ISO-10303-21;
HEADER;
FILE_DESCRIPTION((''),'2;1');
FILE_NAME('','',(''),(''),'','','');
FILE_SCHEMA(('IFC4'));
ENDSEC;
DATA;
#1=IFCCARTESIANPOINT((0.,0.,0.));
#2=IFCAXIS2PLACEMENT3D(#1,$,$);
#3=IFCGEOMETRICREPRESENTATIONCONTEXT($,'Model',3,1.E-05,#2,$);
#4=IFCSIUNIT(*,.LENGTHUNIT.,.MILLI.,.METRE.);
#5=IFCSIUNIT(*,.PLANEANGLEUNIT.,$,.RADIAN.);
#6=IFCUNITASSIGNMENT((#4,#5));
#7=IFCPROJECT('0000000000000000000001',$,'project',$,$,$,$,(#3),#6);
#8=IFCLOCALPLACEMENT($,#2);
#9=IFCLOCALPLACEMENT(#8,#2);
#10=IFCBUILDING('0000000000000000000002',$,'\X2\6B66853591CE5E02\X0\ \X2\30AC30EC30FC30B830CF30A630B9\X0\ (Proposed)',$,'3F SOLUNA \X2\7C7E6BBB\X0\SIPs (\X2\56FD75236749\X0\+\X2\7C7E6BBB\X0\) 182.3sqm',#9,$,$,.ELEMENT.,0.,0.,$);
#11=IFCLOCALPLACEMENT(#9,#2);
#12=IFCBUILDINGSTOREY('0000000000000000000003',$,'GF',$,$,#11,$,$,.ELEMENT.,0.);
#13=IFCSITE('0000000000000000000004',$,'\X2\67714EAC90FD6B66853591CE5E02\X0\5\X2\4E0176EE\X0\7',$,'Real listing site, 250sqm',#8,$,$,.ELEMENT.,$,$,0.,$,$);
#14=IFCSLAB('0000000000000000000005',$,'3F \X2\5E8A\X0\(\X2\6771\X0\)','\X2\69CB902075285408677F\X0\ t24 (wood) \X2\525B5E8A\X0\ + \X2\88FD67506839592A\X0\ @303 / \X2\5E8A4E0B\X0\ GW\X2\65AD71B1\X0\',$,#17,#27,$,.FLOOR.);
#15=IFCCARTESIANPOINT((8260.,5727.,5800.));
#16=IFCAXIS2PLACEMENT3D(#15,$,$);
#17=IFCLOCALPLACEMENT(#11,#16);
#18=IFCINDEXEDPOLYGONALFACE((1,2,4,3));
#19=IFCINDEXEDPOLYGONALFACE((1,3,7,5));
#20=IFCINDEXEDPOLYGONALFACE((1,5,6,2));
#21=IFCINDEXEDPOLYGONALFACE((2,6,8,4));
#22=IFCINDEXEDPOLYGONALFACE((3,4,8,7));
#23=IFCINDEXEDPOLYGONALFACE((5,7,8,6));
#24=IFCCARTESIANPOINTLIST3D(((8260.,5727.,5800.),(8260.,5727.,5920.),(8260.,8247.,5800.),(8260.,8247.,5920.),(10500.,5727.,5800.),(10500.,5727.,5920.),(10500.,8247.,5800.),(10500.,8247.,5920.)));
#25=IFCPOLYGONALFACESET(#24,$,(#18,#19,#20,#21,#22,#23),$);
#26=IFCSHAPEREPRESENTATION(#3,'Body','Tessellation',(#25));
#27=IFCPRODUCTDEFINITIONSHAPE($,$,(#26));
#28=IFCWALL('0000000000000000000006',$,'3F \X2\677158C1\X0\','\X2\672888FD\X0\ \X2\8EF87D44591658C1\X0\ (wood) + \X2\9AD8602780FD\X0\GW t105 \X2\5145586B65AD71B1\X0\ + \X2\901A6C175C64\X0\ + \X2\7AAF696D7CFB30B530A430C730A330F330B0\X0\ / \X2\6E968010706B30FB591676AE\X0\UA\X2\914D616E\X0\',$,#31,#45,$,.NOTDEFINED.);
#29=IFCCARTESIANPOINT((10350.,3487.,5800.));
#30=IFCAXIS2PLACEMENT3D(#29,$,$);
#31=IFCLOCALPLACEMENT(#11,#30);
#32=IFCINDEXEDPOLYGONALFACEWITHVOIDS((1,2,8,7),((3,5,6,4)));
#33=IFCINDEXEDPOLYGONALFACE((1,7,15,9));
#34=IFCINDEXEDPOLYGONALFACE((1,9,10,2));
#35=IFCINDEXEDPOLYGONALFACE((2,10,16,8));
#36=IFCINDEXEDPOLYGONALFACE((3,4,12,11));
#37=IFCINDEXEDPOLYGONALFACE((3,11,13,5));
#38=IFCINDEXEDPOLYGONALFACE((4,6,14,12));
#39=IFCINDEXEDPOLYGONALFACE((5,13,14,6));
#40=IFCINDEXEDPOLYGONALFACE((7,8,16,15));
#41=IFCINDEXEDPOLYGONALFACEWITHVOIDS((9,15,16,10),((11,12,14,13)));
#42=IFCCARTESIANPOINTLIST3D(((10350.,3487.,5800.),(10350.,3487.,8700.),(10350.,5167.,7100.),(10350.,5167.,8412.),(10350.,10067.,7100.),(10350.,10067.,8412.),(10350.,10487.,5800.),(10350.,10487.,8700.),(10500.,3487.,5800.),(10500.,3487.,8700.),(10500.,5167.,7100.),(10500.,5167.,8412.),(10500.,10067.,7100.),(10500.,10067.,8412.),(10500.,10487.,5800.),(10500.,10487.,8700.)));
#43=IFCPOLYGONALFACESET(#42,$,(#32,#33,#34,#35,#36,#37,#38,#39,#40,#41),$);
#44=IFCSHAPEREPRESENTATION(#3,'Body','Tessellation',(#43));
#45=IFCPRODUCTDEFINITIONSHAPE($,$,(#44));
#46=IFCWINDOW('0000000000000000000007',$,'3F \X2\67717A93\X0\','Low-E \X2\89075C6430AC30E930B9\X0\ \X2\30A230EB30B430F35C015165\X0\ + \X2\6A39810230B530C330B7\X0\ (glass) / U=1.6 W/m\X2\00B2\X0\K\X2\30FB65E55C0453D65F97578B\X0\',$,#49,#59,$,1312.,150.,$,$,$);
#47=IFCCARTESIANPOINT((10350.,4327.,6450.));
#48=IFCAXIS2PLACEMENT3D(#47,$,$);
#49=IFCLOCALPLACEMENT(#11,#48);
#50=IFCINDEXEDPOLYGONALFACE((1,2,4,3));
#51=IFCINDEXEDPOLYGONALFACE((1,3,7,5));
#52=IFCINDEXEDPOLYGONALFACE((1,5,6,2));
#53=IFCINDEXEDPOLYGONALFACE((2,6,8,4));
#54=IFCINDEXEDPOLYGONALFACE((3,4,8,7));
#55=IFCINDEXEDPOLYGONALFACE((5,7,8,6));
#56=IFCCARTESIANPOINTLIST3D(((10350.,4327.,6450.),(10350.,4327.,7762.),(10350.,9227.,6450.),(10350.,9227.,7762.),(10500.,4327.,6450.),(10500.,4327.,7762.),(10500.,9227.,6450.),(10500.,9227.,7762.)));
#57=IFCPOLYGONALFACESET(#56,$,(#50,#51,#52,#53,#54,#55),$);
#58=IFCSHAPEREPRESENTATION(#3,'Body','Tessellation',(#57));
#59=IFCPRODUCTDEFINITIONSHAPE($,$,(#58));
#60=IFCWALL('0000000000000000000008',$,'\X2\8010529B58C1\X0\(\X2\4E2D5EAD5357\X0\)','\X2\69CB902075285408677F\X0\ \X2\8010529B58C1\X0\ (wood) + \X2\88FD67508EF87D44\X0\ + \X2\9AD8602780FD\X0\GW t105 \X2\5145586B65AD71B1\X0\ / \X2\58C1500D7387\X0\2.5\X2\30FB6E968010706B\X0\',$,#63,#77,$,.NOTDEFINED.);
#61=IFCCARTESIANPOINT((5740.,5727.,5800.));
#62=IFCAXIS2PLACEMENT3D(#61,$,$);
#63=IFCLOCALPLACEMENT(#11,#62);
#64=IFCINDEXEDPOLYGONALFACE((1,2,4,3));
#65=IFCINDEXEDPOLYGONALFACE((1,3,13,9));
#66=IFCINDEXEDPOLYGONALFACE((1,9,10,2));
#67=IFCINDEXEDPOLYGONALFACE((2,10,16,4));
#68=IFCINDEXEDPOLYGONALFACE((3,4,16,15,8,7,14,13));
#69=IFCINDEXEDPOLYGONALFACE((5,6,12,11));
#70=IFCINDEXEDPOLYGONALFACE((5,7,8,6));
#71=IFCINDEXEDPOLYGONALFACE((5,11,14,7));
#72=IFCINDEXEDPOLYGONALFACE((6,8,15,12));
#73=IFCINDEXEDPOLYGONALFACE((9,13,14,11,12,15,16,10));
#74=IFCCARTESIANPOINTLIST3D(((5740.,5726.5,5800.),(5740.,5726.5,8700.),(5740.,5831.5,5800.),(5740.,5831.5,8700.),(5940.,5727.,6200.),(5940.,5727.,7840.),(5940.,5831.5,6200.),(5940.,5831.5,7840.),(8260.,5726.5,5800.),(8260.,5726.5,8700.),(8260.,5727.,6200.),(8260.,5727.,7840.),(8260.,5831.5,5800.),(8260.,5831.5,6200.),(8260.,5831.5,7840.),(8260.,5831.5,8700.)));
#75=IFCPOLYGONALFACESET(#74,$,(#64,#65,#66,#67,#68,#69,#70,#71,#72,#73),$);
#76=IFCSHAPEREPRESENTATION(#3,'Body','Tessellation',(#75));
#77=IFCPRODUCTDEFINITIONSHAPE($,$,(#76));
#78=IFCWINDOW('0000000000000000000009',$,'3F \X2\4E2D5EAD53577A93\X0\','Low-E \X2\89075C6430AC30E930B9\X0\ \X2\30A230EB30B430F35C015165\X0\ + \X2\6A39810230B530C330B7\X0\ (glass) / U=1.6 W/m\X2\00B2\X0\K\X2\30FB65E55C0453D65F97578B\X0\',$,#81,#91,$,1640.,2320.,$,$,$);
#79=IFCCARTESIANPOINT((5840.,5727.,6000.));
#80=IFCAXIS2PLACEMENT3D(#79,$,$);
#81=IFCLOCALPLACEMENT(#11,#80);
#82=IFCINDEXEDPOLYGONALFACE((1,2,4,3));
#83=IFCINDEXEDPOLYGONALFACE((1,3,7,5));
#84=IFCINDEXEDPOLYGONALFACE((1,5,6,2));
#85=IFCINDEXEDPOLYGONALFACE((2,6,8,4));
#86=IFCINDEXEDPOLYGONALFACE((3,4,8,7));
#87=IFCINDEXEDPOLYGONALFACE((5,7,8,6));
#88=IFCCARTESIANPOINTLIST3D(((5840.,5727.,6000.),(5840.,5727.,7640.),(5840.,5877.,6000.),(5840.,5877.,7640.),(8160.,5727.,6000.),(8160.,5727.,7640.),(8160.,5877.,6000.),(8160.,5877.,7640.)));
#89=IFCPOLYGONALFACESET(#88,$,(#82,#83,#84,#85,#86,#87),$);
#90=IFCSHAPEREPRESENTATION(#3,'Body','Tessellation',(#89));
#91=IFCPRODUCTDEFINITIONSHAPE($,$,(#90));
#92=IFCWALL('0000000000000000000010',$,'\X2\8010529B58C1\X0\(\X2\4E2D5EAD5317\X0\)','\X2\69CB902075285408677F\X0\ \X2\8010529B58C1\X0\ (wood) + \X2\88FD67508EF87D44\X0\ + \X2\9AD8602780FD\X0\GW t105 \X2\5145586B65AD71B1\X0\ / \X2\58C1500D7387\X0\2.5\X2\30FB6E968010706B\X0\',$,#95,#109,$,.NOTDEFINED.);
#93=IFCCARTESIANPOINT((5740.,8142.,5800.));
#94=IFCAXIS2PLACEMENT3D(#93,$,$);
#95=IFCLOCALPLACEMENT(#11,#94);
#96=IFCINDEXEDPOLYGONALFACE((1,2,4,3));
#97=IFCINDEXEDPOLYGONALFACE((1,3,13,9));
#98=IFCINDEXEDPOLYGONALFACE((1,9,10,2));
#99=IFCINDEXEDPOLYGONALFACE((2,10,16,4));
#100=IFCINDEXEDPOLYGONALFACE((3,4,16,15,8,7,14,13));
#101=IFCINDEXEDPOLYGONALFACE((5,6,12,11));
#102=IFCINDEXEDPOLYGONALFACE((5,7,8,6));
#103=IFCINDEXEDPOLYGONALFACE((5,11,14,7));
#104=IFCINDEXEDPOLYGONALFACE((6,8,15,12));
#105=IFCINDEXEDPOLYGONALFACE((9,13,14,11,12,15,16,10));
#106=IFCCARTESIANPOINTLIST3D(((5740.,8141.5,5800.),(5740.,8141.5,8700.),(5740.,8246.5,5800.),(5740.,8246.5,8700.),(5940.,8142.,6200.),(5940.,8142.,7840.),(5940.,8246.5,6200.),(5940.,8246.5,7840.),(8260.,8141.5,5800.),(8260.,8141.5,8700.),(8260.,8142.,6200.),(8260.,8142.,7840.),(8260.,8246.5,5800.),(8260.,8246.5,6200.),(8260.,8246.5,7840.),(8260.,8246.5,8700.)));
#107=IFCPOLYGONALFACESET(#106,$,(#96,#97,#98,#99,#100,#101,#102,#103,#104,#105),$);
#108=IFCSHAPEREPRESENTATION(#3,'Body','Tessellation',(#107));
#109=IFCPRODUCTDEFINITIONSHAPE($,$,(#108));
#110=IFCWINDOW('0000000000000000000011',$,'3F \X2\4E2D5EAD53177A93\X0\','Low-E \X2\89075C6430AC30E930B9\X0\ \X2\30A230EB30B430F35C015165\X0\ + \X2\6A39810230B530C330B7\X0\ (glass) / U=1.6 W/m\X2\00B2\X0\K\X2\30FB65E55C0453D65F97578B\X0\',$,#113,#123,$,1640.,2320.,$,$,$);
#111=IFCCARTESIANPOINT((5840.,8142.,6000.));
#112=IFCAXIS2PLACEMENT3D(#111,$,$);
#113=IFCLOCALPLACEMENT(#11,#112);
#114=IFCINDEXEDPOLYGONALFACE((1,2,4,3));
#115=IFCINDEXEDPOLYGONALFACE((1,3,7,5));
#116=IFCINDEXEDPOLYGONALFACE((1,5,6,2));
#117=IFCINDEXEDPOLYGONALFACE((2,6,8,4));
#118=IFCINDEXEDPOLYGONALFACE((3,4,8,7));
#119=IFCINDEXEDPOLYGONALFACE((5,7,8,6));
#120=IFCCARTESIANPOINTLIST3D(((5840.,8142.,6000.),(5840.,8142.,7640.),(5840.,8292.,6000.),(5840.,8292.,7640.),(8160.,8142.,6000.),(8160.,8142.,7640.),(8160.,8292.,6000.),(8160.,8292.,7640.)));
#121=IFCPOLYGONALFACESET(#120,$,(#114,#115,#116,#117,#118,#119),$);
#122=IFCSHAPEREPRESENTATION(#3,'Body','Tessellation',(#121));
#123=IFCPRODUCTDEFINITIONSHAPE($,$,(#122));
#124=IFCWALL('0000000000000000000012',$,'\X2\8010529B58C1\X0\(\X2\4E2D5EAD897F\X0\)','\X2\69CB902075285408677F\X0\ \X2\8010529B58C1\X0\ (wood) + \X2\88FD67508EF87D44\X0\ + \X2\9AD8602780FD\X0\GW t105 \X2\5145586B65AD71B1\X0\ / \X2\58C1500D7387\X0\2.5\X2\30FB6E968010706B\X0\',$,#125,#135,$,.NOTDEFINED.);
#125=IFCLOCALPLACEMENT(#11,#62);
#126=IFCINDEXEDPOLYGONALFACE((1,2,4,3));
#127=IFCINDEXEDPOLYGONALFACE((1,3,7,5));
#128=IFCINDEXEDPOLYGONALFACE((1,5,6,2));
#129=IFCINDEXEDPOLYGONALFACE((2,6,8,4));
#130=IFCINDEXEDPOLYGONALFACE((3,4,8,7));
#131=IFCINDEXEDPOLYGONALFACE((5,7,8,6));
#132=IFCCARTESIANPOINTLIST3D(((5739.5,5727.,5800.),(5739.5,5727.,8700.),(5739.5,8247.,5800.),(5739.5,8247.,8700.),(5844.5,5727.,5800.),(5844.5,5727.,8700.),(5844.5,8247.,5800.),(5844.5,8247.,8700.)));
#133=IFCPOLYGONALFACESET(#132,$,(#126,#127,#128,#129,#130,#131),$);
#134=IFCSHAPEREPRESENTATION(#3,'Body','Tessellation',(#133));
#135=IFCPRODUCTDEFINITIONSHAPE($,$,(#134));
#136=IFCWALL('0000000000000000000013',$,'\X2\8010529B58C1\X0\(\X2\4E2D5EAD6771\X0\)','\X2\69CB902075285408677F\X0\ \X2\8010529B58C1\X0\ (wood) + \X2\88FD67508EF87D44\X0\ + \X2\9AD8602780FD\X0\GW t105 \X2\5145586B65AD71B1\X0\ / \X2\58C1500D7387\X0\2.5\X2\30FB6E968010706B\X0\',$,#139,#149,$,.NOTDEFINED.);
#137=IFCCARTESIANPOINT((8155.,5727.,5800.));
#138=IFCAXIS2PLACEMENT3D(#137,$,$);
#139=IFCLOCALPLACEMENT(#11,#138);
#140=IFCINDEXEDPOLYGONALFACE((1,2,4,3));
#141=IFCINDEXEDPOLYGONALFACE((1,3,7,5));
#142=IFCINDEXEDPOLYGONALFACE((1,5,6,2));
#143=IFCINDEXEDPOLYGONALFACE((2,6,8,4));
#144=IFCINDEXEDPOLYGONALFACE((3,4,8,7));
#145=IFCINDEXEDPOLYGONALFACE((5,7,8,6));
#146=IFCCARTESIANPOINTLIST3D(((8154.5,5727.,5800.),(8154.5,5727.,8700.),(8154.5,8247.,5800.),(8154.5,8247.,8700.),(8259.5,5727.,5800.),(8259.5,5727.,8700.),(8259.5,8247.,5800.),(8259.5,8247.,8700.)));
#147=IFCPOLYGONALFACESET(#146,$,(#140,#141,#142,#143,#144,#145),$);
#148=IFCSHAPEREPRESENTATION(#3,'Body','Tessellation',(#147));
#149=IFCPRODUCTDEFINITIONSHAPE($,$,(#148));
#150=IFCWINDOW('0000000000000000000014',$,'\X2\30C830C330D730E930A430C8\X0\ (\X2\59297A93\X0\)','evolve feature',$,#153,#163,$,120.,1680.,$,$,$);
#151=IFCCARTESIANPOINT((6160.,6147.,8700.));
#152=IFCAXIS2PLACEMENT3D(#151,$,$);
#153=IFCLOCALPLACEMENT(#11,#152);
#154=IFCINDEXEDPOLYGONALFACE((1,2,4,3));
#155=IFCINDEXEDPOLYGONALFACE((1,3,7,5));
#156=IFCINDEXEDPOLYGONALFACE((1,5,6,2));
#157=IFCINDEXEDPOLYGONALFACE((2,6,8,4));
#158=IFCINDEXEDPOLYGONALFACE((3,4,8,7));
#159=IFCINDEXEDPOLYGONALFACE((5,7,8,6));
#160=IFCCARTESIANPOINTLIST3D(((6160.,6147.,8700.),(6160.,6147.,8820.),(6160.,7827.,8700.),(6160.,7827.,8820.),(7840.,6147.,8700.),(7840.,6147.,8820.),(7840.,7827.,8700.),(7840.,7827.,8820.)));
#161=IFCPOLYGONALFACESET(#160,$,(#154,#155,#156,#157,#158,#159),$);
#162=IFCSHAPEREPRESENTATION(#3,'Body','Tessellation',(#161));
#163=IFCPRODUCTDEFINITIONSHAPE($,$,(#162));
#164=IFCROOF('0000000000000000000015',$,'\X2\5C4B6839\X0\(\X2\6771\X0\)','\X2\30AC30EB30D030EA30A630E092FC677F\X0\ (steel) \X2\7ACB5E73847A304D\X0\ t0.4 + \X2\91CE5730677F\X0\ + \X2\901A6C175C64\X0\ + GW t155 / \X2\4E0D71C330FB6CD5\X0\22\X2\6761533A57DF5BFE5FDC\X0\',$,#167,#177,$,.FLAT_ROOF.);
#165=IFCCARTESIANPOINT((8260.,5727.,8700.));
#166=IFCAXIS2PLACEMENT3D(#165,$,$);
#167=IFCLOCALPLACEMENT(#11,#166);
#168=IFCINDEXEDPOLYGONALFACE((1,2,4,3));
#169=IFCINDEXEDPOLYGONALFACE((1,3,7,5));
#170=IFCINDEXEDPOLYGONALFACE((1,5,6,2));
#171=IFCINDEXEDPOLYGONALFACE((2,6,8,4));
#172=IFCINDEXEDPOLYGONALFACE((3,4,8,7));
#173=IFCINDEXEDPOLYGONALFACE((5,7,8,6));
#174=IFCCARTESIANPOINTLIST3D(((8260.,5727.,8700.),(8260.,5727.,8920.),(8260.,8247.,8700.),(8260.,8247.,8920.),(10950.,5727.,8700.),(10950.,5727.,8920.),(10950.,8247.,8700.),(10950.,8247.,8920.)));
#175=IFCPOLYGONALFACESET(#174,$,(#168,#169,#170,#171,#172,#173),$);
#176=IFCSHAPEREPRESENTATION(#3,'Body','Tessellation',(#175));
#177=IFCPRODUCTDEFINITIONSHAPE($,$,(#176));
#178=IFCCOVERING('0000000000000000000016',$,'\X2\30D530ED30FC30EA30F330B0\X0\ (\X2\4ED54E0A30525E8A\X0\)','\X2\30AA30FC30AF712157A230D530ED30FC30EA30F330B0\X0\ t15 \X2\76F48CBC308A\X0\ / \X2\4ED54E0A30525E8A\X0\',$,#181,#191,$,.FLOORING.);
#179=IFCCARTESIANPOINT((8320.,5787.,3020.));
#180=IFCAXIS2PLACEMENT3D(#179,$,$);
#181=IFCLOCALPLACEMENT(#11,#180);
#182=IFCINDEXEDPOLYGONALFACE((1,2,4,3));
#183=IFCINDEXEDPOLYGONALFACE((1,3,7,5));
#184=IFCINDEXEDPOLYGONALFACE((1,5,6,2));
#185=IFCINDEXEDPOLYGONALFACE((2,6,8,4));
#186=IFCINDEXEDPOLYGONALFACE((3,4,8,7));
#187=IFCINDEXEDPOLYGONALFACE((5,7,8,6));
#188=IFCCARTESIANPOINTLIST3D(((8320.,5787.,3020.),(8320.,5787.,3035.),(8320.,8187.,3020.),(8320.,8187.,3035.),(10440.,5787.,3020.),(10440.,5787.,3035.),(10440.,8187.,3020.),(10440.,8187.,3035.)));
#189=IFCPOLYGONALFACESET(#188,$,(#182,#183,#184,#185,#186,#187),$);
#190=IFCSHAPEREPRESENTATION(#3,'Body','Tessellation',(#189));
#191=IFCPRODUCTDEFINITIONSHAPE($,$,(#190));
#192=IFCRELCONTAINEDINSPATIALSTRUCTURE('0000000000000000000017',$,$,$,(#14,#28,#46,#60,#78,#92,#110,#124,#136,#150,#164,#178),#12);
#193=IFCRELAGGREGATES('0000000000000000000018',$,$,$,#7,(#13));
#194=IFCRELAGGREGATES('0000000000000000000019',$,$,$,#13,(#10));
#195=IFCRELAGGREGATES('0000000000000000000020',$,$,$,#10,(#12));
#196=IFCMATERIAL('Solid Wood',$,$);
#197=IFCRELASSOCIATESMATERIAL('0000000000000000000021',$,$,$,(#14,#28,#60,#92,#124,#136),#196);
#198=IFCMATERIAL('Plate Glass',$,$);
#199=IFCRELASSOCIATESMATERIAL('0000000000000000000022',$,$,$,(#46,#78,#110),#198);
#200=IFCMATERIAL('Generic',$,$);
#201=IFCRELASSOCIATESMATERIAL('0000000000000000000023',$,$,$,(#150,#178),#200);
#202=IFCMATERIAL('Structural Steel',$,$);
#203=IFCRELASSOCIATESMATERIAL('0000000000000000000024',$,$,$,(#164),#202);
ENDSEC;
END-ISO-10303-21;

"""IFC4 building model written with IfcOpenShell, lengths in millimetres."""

from ifc_helpers import new_model, si_unit, frame, frame_2d, origin, place, context, project, spatial, rectangle, extrude, material, element, fill, save


model = new_model("IFC4")

# Units and contexts
model_context = context("Model", 3, precision=1e-05, world=origin())
ifc_project = project(units=[si_unit("LENGTHUNIT", "METRE", prefix="MILLI"), si_unit("PLANEANGLEUNIT", "RADIAN")], contexts=[model_context])

# Site, building, storey
site_placement = place(None, origin())
site = spatial("IfcSite", under=ifc_project, at=site_placement, Name="東京都武蔵野市5丁目7", ObjectType="Real listing site, 250sqm", CompositionType="ELEMENT", RefElevation=0.0)
building_placement = place(site_placement, origin())
building = spatial("IfcBuilding", under=site, at=building_placement, Name="武蔵野市 ガレージハウス (Proposed)", ObjectType="3F SOLUNA 籾殻SIPs (国産杉+籾殻) 182.3sqm", CompositionType="ELEMENT", ElevationOfRefHeight=0.0, ElevationOfTerrain=0.0)
storey_placement = place(building_placement, origin())
storey = spatial("IfcBuildingStorey", under=building, at=storey_placement, Name="GF", CompositionType="ELEMENT", Elevation=0.0)

# Slab
ifc_material_1 = material(Name="Solid Wood")
slab_placement = place(storey_placement, frame((8260.0, 5727.0, 5800.0)))
element("IfcSlab", 1, at=slab_placement, inside=storey, material=ifc_material_1, Name="3F 床(東)", Description="構造用合板 t24 (wood) 剛床 + 製材根太 @303 / 床下 GW断熱", PredefinedType="FLOOR", context=model_context, shape_type="SweptSolid", body=[
    extrude(rectangle(XDim=2240.0, YDim=2520.0, at=frame_2d((1120.0, 1260.0))), frame((8260.0, 5727.0, 5800.0)), (0.0, 0.0, 1.0), 120.0),
])

# Walls, openings, windows
wall_1_placement = place(storey_placement, frame((10350.0, 3487.0, 5800.0)))
wall_1 = element("IfcWall", 2, at=wall_1_placement, inside=storey, material=ifc_material_1, Name="3F 東壁", Description="木製 軸組外壁 (wood) + 高性能GW t105 充填断熱 + 通気層 + 窯業系サイディング / 準耐火・外皮UA配慮", PredefinedType="NOTDEFINED", context=model_context, shape_type="SweptSolid", body=[
    extrude(rectangle(XDim=150.0, YDim=7000.0, at=frame_2d((75.0, 3500.0))), frame((10350.0, 3487.0, 5800.0)), (0.0, 0.0, 1.0), 2900.0),
])
opening_1_placement = place(storey_placement, frame((10350.0, 4327.0, 6450.0)))
opening_1 = element("IfcOpeningElement", 3, at=opening_1_placement, cuts=wall_1, PredefinedType="NOTDEFINED", context=model_context, shape_type="SweptSolid", body=[
    extrude(rectangle(XDim=150.0, YDim=4900.0, at=frame_2d((75.0, 2450.0))), frame((10350.0, 4327.0, 6450.0)), (0.0, 0.0, 1.0), 1312.0),
])
ifc_material_2 = material(Name="Plate Glass")
window_1_placement = place(storey_placement, frame((10350.0, 4327.0, 6450.0)))
window_1 = element("IfcWindow", 4, at=window_1_placement, inside=storey, material=ifc_material_2, Name="3F 東窓", Description="Low-E 複層ガラス アルゴン封入 + 樹脂サッシ (glass) / U=1.6 W/m²K・日射取得型", OverallHeight=1312.0, OverallWidth=150.0, context=model_context, shape_type="SweptSolid", body=[
    extrude(rectangle(XDim=150.0, YDim=4900.0, at=frame_2d((75.0, 2450.0))), frame((10350.0, 4327.0, 6450.0)), (0.0, 0.0, 1.0), 1312.0),
])
fill(opening_1, window_1)
wall_2_placement = place(storey_placement, frame((5740.0, 5727.0, 5800.0)))
wall_2 = element("IfcWall", 5, at=wall_2_placement, inside=storey, material=ifc_material_1, Name="耐力壁(中庭南)", Description="構造用合板 耐力壁 (wood) + 製材軸組 + 高性能GW t105 充填断熱 / 壁倍率2.5・準耐火", PredefinedType="NOTDEFINED", context=model_context, shape_type="SweptSolid", body=[
    extrude(rectangle(XDim=2520.0, YDim=105.0, at=frame_2d((1260.0, 52.0))), frame((5740.0, 5727.0, 5800.0)), (0.0, 0.0, 1.0), 2900.0),
])
opening_2_placement = place(storey_placement, frame((5840.0, 5727.0, 6000.0)))
opening_2 = element("IfcOpeningElement", 6, at=opening_2_placement, cuts=wall_2, PredefinedType="NOTDEFINED", context=model_context, shape_type="SweptSolid", body=[
    extrude(rectangle(XDim=2320.0, YDim=150.0, at=frame_2d((1160.0, 75.0))), frame((5840.0, 5727.0, 6000.0)), (0.0, 0.0, 1.0), 1640.0),
])
window_2_placement = place(storey_placement, frame((5840.0, 5727.0, 6000.0)))
window_2 = element("IfcWindow", 7, at=window_2_placement, inside=storey, material=ifc_material_2, Name="3F 中庭南窓", Description="Low-E 複層ガラス アルゴン封入 + 樹脂サッシ (glass) / U=1.6 W/m²K・日射取得型", OverallHeight=1640.0, OverallWidth=2320.0, context=model_context, shape_type="SweptSolid", body=[
    extrude(rectangle(XDim=2320.0, YDim=150.0, at=frame_2d((1160.0, 75.0))), frame((5840.0, 5727.0, 6000.0)), (0.0, 0.0, 1.0), 1640.0),
])
fill(opening_2, window_2)
wall_3_placement = place(storey_placement, frame((5740.0, 8142.0, 5800.0)))
wall_3 = element("IfcWall", 8, at=wall_3_placement, inside=storey, material=ifc_material_1, Name="耐力壁(中庭北)", Description="構造用合板 耐力壁 (wood) + 製材軸組 + 高性能GW t105 充填断熱 / 壁倍率2.5・準耐火", PredefinedType="NOTDEFINED", context=model_context, shape_type="SweptSolid", body=[
    extrude(rectangle(XDim=2520.0, YDim=105.0, at=frame_2d((1260.0, 52.0))), frame((5740.0, 8142.0, 5800.0)), (0.0, 0.0, 1.0), 2900.0),
])
opening_3_placement = place(storey_placement, frame((5840.0, 8142.0, 6000.0)))
opening_3 = element("IfcOpeningElement", 9, at=opening_3_placement, cuts=wall_3, PredefinedType="NOTDEFINED", context=model_context, shape_type="SweptSolid", body=[
    extrude(rectangle(XDim=2320.0, YDim=150.0, at=frame_2d((1160.0, 75.0))), frame((5840.0, 8142.0, 6000.0)), (0.0, 0.0, 1.0), 1640.0),
])
window_3_placement = place(storey_placement, frame((5840.0, 8142.0, 6000.0)))
window_3 = element("IfcWindow", 10, at=window_3_placement, inside=storey, material=ifc_material_2, Name="3F 中庭北窓", Description="Low-E 複層ガラス アルゴン封入 + 樹脂サッシ (glass) / U=1.6 W/m²K・日射取得型", OverallHeight=1640.0, OverallWidth=2320.0, context=model_context, shape_type="SweptSolid", body=[
    extrude(rectangle(XDim=2320.0, YDim=150.0, at=frame_2d((1160.0, 75.0))), frame((5840.0, 8142.0, 6000.0)), (0.0, 0.0, 1.0), 1640.0),
])
fill(opening_3, window_3)

# Walls
wall_4_placement = place(storey_placement, frame((5740.0, 5727.0, 5800.0)))
element("IfcWall", 11, at=wall_4_placement, inside=storey, material=ifc_material_1, Name="耐力壁(中庭西)", Description="構造用合板 耐力壁 (wood) + 製材軸組 + 高性能GW t105 充填断熱 / 壁倍率2.5・準耐火", PredefinedType="NOTDEFINED", context=model_context, shape_type="SweptSolid", body=[
    extrude(rectangle(XDim=105.0, YDim=2520.0, at=frame_2d((52.0, 1260.0))), frame((5740.0, 5727.0, 5800.0)), (0.0, 0.0, 1.0), 2900.0),
])
wall_5_placement = place(storey_placement, frame((8155.0, 5727.0, 5800.0)))
element("IfcWall", 12, at=wall_5_placement, inside=storey, material=ifc_material_1, Name="耐力壁(中庭東)", Description="構造用合板 耐力壁 (wood) + 製材軸組 + 高性能GW t105 充填断熱 / 壁倍率2.5・準耐火", PredefinedType="NOTDEFINED", context=model_context, shape_type="SweptSolid", body=[
    extrude(rectangle(XDim=105.0, YDim=2520.0, at=frame_2d((52.0, 1260.0))), frame((8155.0, 5727.0, 5800.0)), (0.0, 0.0, 1.0), 2900.0),
])

# Window
ifc_material_3 = material(Name="Generic")
window_4_placement = place(storey_placement, frame((6160.0, 6147.0, 8700.0)))
element("IfcWindow", 13, at=window_4_placement, inside=storey, material=ifc_material_3, Name="トップライト (天窓)", Description="evolve feature", OverallHeight=120.0, OverallWidth=1680.0, context=model_context, shape_type="SweptSolid", body=[
    extrude(rectangle(XDim=1680.0, YDim=1680.0, at=frame_2d((840.0, 840.0))), frame((6160.0, 6147.0, 8700.0)), (0.0, 0.0, 1.0), 120.0),
])

# Roof
ifc_material_4 = material(Name="Structural Steel")
for number, where, name in (
    (14, (8260.0, 5727.0, 8700.0), "屋根(東)"),
):
    element("IfcRoof", number, at=place(storey_placement, frame(where)), inside=storey, material=ifc_material_4, Name=name, Description="ガルバリウム鋼板 (steel) 立平葺き t0.4 + 野地板 + 通気層 + GW t155 / 不燃・法22条区域対応", PredefinedType="FLAT_ROOF", context=model_context, shape_type="SweptSolid", body=[
        extrude(rectangle(XDim=2690.0, YDim=2520.0, at=frame_2d((1345.0, 1260.0))), frame((8260.0, 5727.0, 8700.0)), (0.0, 0.0, 1.0), 220.0),
    ])

# Covering
covering_1_placement = place(storey_placement, frame((8320.0, 5787.0, 3020.0)))
element("IfcCovering", 15, at=covering_1_placement, inside=storey, material=ifc_material_3, Name="フローリング (仕上げ床)", Description="オーク無垢フローリング t15 直貼り / 仕上げ床", PredefinedType="FLOORING", context=model_context, shape_type="SweptSolid", body=[
    extrude(rectangle(XDim=2120.0, YDim=2400.0, at=frame_2d((1060.0, 1200.0))), frame((8320.0, 5787.0, 3020.0)), (0.0, 0.0, 1.0), 15.0),
])

save(model, "model.ifc")
